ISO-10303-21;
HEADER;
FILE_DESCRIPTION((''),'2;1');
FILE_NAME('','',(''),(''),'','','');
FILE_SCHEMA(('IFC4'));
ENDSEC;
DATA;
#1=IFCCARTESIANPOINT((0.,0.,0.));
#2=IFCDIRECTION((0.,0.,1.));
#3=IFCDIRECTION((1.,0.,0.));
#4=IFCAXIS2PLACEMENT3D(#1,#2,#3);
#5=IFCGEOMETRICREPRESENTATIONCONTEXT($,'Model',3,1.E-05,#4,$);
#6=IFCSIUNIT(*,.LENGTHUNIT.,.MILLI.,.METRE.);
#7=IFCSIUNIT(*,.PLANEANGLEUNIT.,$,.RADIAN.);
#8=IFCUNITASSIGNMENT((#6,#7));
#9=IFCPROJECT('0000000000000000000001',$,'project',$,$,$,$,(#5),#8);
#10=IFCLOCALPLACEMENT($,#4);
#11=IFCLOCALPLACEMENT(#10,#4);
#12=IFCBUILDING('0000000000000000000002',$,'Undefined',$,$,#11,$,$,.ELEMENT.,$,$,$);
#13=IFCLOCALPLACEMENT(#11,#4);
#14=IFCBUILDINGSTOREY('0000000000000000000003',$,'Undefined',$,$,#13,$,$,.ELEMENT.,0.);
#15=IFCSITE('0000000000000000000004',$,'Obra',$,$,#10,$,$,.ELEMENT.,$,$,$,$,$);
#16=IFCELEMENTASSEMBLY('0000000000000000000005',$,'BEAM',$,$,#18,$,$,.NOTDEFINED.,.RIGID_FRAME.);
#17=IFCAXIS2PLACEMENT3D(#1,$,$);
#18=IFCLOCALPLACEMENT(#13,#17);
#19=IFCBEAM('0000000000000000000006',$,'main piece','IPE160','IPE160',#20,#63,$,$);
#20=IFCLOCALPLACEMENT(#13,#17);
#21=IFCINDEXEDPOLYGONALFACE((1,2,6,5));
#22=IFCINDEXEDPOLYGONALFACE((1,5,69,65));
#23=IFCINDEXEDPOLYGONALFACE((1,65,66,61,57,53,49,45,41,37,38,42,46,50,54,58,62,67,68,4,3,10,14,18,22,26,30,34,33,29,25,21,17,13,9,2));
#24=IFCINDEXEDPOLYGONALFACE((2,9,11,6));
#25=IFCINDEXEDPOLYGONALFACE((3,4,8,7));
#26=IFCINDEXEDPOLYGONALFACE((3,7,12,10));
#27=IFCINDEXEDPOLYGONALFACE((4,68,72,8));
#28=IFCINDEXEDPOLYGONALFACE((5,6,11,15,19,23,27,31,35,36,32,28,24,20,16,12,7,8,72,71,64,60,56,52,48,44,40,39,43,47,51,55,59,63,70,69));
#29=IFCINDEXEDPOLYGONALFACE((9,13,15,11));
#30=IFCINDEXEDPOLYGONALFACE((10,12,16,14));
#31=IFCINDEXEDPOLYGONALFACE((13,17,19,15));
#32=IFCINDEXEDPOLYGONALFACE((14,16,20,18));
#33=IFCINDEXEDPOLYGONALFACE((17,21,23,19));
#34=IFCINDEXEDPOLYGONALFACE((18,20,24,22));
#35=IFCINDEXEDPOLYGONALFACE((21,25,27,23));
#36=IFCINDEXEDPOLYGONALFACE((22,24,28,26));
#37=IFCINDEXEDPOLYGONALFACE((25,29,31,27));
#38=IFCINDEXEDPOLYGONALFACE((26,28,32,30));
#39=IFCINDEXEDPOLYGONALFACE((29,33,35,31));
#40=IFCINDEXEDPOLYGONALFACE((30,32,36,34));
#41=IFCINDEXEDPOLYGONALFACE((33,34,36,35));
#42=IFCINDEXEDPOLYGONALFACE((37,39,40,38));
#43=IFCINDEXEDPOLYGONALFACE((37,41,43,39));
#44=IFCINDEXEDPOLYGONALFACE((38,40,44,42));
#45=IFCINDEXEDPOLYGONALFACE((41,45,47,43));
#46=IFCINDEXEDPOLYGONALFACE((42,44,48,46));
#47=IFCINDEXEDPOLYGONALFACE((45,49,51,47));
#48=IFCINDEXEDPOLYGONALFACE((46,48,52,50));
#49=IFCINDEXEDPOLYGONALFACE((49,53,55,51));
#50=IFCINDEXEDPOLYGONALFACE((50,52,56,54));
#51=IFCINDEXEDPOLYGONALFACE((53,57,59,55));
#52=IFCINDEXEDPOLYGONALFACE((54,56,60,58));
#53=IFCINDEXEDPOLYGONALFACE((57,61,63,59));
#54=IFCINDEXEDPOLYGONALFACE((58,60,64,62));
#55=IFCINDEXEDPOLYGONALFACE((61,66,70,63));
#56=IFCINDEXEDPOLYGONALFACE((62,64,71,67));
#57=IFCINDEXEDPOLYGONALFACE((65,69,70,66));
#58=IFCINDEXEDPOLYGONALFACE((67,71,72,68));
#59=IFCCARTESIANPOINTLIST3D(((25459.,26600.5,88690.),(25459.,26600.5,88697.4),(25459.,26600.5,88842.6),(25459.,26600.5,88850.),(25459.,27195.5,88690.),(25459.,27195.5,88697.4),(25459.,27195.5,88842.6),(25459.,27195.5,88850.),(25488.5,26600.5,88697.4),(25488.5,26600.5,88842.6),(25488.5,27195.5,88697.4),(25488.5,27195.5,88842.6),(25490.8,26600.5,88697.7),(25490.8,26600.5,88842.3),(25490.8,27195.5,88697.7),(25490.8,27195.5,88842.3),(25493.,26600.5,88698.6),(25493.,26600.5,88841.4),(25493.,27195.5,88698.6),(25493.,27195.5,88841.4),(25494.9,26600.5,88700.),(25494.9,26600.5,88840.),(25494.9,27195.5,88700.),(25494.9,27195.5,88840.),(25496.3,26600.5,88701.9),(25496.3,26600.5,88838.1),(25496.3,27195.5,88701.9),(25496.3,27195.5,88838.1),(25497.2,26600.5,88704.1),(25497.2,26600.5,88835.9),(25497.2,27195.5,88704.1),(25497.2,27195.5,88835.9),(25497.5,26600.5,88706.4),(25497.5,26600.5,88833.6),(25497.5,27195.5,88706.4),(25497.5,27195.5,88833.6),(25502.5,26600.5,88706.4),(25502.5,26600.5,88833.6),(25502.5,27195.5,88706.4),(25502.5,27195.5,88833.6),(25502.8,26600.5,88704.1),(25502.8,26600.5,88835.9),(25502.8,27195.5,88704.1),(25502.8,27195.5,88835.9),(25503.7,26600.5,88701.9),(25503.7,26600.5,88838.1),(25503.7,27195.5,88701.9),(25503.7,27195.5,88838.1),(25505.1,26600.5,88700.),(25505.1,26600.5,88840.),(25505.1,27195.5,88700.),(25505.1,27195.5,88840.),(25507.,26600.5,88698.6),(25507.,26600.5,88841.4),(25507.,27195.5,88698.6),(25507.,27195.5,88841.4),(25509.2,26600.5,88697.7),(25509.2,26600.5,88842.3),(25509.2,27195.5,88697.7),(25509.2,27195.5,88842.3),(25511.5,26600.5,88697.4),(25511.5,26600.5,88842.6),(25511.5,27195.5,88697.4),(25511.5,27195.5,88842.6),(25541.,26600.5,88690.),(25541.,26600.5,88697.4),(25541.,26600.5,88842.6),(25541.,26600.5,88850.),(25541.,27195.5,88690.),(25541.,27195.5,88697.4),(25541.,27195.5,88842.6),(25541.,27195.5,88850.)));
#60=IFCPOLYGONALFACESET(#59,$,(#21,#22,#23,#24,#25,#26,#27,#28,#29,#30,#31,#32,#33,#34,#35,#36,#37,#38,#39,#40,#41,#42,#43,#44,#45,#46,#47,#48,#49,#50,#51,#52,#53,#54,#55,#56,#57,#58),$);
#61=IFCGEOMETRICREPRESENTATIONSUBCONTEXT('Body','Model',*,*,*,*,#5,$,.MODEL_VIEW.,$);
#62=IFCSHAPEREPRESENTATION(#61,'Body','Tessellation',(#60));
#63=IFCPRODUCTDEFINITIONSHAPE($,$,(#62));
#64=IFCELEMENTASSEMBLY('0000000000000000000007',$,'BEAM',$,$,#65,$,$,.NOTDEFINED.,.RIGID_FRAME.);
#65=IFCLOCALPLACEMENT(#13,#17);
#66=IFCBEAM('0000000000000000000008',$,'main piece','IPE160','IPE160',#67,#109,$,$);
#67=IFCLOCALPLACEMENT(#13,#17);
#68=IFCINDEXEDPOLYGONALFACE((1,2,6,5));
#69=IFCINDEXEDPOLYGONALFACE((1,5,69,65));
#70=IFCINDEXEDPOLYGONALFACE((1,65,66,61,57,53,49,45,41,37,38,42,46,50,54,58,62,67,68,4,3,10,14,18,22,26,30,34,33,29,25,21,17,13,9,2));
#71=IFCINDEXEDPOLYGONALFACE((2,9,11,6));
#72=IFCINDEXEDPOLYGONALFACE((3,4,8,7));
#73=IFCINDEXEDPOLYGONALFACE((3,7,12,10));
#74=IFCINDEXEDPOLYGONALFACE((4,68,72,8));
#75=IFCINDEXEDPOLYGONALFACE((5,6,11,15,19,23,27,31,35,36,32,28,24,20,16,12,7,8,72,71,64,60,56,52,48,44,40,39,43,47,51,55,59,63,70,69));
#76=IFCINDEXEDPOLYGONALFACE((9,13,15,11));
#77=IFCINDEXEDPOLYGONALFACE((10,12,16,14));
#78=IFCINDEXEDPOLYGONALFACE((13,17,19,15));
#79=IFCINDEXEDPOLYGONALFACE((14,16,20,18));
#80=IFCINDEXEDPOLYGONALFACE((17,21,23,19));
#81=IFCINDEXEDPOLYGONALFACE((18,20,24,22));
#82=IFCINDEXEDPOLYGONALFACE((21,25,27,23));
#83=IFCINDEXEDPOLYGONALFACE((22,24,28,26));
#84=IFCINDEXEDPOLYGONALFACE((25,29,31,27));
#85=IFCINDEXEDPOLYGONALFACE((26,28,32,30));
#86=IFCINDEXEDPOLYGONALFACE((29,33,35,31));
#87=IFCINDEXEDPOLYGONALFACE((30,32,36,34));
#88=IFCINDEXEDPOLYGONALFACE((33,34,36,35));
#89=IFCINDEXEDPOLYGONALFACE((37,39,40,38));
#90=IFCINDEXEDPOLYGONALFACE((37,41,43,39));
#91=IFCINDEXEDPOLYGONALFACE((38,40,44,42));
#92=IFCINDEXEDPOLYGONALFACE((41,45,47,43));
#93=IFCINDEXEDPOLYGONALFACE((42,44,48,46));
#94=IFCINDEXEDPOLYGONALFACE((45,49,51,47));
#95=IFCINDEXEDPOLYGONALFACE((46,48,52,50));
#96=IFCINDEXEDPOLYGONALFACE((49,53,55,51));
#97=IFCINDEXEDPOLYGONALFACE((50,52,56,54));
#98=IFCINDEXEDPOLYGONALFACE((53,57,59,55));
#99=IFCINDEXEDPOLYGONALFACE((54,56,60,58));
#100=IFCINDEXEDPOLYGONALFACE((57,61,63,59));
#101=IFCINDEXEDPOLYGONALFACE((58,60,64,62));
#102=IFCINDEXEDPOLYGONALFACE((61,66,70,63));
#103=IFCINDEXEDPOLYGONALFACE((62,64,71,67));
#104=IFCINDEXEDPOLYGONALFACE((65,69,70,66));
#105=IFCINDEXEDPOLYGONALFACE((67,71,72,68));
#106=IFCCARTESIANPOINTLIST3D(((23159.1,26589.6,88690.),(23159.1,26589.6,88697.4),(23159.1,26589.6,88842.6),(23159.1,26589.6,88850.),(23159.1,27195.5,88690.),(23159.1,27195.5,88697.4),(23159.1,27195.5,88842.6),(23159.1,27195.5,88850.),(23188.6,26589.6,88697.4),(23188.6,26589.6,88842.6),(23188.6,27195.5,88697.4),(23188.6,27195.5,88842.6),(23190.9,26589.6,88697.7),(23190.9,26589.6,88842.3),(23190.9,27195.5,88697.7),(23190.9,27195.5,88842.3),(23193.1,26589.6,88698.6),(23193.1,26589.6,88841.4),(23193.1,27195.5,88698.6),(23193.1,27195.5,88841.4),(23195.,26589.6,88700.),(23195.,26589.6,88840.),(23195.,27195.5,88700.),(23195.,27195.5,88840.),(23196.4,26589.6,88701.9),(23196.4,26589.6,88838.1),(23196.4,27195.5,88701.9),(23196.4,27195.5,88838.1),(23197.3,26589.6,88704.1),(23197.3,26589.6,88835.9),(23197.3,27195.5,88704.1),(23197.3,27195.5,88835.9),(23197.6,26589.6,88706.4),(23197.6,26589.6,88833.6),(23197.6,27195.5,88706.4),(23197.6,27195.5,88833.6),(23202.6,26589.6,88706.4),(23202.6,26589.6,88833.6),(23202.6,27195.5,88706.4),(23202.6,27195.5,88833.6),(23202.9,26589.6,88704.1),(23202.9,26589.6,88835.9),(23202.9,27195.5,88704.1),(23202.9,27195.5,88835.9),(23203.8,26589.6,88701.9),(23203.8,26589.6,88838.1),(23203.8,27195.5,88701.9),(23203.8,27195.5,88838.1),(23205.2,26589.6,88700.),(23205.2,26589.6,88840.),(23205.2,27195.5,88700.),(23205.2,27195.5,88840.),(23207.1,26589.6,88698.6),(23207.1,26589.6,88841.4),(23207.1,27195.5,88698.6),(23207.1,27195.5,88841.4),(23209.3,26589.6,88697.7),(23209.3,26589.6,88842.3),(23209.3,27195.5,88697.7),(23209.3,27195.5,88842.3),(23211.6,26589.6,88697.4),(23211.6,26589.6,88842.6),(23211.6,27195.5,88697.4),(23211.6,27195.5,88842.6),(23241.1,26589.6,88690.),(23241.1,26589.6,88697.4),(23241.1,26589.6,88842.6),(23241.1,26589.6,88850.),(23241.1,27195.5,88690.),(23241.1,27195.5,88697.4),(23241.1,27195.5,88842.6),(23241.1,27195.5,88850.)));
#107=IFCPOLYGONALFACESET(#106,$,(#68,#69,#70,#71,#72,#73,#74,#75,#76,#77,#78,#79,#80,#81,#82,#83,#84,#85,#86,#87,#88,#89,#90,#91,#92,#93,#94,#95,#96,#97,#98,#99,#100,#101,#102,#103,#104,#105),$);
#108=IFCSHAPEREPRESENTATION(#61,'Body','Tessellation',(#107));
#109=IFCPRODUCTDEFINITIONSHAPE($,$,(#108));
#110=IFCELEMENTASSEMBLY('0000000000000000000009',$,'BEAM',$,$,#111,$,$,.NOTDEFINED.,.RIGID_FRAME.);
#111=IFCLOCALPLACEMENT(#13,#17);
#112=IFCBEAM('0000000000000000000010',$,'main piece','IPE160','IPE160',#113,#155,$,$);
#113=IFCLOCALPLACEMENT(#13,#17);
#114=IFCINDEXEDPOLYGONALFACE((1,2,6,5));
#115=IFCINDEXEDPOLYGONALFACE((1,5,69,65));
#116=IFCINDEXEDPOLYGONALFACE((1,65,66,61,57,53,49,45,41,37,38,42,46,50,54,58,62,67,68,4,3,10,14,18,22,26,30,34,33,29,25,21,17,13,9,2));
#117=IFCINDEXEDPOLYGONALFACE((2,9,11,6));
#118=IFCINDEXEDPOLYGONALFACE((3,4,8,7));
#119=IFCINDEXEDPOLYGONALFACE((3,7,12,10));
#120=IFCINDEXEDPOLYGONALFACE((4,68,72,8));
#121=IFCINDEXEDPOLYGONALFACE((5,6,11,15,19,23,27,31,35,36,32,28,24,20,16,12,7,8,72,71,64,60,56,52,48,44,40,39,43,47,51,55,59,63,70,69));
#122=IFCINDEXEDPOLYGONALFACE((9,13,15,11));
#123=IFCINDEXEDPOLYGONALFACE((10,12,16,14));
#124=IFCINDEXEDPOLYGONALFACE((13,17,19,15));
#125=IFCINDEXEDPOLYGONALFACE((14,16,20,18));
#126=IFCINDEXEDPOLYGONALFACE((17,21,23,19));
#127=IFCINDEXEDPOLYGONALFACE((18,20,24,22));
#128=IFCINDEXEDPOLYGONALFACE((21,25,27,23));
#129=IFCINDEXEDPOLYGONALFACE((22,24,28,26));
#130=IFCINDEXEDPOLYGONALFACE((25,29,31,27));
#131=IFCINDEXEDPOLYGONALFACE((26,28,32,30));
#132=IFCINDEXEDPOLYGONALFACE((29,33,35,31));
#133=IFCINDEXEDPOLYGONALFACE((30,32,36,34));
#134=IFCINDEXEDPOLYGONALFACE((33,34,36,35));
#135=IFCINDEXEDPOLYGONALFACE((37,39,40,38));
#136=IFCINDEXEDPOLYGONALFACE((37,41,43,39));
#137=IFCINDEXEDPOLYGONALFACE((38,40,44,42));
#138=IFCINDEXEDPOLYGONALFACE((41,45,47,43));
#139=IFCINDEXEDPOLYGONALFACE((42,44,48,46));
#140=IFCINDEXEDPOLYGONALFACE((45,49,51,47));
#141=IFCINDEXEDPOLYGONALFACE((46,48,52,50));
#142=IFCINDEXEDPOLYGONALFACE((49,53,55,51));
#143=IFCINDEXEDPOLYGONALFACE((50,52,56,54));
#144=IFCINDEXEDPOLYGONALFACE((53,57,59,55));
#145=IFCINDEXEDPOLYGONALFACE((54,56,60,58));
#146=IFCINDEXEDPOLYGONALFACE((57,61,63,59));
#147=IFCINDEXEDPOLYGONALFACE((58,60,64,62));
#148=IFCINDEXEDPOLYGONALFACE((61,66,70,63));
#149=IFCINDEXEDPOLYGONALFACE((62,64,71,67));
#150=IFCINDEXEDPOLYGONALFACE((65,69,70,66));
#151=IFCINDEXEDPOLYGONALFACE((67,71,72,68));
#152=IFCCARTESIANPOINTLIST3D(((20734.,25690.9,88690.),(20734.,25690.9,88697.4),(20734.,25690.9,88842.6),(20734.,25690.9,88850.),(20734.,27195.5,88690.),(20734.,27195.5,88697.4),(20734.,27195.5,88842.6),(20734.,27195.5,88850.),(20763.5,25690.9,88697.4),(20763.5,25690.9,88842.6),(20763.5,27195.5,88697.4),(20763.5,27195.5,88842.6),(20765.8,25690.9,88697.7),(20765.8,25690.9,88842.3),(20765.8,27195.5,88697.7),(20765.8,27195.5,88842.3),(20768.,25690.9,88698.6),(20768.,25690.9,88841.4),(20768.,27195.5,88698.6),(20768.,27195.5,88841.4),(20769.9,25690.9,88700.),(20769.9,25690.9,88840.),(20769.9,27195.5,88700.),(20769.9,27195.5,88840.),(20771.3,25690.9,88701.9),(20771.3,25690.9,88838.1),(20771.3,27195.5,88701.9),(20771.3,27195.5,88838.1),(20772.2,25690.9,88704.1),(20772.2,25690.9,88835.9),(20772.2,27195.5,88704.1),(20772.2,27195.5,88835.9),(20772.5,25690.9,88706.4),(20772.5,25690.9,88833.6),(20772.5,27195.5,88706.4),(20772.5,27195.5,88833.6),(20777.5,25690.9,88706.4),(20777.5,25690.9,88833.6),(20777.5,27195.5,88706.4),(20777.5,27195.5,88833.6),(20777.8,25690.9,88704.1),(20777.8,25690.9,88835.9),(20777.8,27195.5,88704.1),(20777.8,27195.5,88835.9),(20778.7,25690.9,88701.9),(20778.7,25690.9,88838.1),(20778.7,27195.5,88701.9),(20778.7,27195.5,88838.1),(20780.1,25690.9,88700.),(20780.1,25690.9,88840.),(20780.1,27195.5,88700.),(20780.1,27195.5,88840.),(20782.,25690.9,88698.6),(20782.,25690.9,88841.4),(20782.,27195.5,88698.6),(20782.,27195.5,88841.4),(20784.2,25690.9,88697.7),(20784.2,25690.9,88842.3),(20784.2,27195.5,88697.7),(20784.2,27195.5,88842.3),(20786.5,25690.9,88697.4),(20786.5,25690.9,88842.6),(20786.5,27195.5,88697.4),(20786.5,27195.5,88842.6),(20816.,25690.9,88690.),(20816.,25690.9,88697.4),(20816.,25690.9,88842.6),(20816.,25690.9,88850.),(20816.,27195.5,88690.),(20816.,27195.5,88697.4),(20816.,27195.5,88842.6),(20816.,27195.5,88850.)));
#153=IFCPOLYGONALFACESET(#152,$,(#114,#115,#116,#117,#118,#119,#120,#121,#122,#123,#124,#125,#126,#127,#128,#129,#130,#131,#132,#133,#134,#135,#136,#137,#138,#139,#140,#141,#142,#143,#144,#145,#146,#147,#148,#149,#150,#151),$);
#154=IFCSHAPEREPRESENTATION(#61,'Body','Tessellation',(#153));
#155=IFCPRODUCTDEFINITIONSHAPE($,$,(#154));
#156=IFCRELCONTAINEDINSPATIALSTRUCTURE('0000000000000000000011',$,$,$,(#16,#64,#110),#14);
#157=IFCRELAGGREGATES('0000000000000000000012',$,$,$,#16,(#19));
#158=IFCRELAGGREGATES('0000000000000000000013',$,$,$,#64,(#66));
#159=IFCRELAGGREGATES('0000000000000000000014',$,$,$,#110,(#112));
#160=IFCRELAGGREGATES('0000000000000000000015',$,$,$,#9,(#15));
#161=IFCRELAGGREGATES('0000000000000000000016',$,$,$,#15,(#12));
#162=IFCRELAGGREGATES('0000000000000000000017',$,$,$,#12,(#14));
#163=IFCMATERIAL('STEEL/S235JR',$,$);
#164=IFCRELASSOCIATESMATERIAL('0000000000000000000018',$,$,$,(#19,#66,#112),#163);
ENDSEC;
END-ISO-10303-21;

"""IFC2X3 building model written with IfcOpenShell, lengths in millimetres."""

from ifc_helpers import new_model, si_unit, frame, origin_with_axes, origin_2d_with_axis, place, context, subcontext, project, spatial, i_section, extrude, material, element, aggregate, save


model = new_model("IFC2X3")

# Units and contexts
model_context = context("Model", 3, precision=1e-05, world=origin_with_axes())
body_context = subcontext(model_context, "Body", "Model", "MODEL_VIEW")
ifc_project = project(units=[si_unit("LENGTHUNIT", "METRE", prefix="MILLI"), si_unit("PLANEANGLEUNIT", "RADIAN")], contexts=[model_context])

# Site, building, storey
site_placement = place(None, origin_with_axes())
site = spatial("IfcSite", under=ifc_project, at=site_placement, Name="Obra", CompositionType="ELEMENT")
building_placement = place(site_placement, origin_with_axes())
building = spatial("IfcBuilding", under=site, at=building_placement, Name="Undefined", CompositionType="ELEMENT")
storey_placement = place(building_placement, origin_with_axes())
storey = spatial("IfcBuildingStorey", under=building, at=storey_placement, Name="Undefined", CompositionType="ELEMENT", Elevation=0.0)

# Element assemblies, beams
ifc_material_1 = material(Name="STEEL/S235JR")
assembly_1_placement = place(storey_placement, origin_with_axes())
assembly_1 = element("IfcElementAssembly", 1, at=assembly_1_placement, inside=storey, Name="BEAM", AssemblyPlace="NOTDEFINED", PredefinedType="RIGID_FRAME")
beam_1_placement = place(assembly_1_placement, frame((25500.0, 26600.5, 88770.0), z_axis=(0.0, 0.0, 1.0), x_axis=(0.0, 1.0, 0.0)))
beam_1 = element("IfcBeam", 2, at=beam_1_placement, material=ifc_material_1, Name="main piece", Description="IPE160", ObjectType="IPE160", context=body_context, shape_type="SweptSolid", body=[
    extrude(i_section(OverallWidth=82.0, OverallDepth=160.0, WebThickness=5.0, FlangeThickness=7.4, FilletRadius=9.0, at=origin_2d_with_axis()), frame((595.0, 0.0, 0.0), z_axis=(-1.0, 0.0, 0.0), x_axis=(0.0, -1.0, 0.0)), (0.0, 0.0, 1.0), 595.0),
])
aggregate(assembly_1, [beam_1])
assembly_2_placement = place(storey_placement, origin_with_axes())
assembly_2 = element("IfcElementAssembly", 3, at=assembly_2_placement, inside=storey, Name="BEAM", AssemblyPlace="NOTDEFINED", PredefinedType="RIGID_FRAME")
beam_2_placement = place(assembly_2_placement, frame((23200.1, 26589.6, 88770.0), z_axis=(0.0, 0.0, 1.0), x_axis=(0.0, 1.0, 0.0)))
beam_2 = element("IfcBeam", 4, at=beam_2_placement, material=ifc_material_1, Name="main piece", Description="IPE160", ObjectType="IPE160", context=body_context, shape_type="SweptSolid", body=[
    extrude(i_section(OverallWidth=82.0, OverallDepth=160.0, WebThickness=5.0, FlangeThickness=7.4, FilletRadius=9.0, at=origin_2d_with_axis()), frame((605.9, 0.0, 0.0), z_axis=(-1.0, 0.0, 0.0), x_axis=(0.0, -1.0, 0.0)), (0.0, 0.0, 1.0), 605.9),
])
aggregate(assembly_2, [beam_2])
assembly_3_placement = place(storey_placement, origin_with_axes())
assembly_3 = element("IfcElementAssembly", 5, at=assembly_3_placement, inside=storey, Name="BEAM", AssemblyPlace="NOTDEFINED", PredefinedType="RIGID_FRAME")
beam_3_placement = place(assembly_3_placement, frame((20775.0, 25690.9, 88770.0), z_axis=(0.0, 0.0, 1.0), x_axis=(0.0, 1.0, 0.0)))
beam_3 = element("IfcBeam", 6, at=beam_3_placement, material=ifc_material_1, Name="main piece", Description="IPE160", ObjectType="IPE160", context=body_context, shape_type="SweptSolid", body=[
    extrude(i_section(OverallWidth=82.0, OverallDepth=160.0, WebThickness=5.0, FlangeThickness=7.4, FilletRadius=9.0, at=origin_2d_with_axis()), frame((1504.6, 0.0, 0.0), z_axis=(-1.0, 0.0, 0.0), x_axis=(0.0, -1.0, 0.0)), (0.0, 0.0, 1.0), 1504.6),
])
aggregate(assembly_3, [beam_3])

save(model, "model.ifc")
